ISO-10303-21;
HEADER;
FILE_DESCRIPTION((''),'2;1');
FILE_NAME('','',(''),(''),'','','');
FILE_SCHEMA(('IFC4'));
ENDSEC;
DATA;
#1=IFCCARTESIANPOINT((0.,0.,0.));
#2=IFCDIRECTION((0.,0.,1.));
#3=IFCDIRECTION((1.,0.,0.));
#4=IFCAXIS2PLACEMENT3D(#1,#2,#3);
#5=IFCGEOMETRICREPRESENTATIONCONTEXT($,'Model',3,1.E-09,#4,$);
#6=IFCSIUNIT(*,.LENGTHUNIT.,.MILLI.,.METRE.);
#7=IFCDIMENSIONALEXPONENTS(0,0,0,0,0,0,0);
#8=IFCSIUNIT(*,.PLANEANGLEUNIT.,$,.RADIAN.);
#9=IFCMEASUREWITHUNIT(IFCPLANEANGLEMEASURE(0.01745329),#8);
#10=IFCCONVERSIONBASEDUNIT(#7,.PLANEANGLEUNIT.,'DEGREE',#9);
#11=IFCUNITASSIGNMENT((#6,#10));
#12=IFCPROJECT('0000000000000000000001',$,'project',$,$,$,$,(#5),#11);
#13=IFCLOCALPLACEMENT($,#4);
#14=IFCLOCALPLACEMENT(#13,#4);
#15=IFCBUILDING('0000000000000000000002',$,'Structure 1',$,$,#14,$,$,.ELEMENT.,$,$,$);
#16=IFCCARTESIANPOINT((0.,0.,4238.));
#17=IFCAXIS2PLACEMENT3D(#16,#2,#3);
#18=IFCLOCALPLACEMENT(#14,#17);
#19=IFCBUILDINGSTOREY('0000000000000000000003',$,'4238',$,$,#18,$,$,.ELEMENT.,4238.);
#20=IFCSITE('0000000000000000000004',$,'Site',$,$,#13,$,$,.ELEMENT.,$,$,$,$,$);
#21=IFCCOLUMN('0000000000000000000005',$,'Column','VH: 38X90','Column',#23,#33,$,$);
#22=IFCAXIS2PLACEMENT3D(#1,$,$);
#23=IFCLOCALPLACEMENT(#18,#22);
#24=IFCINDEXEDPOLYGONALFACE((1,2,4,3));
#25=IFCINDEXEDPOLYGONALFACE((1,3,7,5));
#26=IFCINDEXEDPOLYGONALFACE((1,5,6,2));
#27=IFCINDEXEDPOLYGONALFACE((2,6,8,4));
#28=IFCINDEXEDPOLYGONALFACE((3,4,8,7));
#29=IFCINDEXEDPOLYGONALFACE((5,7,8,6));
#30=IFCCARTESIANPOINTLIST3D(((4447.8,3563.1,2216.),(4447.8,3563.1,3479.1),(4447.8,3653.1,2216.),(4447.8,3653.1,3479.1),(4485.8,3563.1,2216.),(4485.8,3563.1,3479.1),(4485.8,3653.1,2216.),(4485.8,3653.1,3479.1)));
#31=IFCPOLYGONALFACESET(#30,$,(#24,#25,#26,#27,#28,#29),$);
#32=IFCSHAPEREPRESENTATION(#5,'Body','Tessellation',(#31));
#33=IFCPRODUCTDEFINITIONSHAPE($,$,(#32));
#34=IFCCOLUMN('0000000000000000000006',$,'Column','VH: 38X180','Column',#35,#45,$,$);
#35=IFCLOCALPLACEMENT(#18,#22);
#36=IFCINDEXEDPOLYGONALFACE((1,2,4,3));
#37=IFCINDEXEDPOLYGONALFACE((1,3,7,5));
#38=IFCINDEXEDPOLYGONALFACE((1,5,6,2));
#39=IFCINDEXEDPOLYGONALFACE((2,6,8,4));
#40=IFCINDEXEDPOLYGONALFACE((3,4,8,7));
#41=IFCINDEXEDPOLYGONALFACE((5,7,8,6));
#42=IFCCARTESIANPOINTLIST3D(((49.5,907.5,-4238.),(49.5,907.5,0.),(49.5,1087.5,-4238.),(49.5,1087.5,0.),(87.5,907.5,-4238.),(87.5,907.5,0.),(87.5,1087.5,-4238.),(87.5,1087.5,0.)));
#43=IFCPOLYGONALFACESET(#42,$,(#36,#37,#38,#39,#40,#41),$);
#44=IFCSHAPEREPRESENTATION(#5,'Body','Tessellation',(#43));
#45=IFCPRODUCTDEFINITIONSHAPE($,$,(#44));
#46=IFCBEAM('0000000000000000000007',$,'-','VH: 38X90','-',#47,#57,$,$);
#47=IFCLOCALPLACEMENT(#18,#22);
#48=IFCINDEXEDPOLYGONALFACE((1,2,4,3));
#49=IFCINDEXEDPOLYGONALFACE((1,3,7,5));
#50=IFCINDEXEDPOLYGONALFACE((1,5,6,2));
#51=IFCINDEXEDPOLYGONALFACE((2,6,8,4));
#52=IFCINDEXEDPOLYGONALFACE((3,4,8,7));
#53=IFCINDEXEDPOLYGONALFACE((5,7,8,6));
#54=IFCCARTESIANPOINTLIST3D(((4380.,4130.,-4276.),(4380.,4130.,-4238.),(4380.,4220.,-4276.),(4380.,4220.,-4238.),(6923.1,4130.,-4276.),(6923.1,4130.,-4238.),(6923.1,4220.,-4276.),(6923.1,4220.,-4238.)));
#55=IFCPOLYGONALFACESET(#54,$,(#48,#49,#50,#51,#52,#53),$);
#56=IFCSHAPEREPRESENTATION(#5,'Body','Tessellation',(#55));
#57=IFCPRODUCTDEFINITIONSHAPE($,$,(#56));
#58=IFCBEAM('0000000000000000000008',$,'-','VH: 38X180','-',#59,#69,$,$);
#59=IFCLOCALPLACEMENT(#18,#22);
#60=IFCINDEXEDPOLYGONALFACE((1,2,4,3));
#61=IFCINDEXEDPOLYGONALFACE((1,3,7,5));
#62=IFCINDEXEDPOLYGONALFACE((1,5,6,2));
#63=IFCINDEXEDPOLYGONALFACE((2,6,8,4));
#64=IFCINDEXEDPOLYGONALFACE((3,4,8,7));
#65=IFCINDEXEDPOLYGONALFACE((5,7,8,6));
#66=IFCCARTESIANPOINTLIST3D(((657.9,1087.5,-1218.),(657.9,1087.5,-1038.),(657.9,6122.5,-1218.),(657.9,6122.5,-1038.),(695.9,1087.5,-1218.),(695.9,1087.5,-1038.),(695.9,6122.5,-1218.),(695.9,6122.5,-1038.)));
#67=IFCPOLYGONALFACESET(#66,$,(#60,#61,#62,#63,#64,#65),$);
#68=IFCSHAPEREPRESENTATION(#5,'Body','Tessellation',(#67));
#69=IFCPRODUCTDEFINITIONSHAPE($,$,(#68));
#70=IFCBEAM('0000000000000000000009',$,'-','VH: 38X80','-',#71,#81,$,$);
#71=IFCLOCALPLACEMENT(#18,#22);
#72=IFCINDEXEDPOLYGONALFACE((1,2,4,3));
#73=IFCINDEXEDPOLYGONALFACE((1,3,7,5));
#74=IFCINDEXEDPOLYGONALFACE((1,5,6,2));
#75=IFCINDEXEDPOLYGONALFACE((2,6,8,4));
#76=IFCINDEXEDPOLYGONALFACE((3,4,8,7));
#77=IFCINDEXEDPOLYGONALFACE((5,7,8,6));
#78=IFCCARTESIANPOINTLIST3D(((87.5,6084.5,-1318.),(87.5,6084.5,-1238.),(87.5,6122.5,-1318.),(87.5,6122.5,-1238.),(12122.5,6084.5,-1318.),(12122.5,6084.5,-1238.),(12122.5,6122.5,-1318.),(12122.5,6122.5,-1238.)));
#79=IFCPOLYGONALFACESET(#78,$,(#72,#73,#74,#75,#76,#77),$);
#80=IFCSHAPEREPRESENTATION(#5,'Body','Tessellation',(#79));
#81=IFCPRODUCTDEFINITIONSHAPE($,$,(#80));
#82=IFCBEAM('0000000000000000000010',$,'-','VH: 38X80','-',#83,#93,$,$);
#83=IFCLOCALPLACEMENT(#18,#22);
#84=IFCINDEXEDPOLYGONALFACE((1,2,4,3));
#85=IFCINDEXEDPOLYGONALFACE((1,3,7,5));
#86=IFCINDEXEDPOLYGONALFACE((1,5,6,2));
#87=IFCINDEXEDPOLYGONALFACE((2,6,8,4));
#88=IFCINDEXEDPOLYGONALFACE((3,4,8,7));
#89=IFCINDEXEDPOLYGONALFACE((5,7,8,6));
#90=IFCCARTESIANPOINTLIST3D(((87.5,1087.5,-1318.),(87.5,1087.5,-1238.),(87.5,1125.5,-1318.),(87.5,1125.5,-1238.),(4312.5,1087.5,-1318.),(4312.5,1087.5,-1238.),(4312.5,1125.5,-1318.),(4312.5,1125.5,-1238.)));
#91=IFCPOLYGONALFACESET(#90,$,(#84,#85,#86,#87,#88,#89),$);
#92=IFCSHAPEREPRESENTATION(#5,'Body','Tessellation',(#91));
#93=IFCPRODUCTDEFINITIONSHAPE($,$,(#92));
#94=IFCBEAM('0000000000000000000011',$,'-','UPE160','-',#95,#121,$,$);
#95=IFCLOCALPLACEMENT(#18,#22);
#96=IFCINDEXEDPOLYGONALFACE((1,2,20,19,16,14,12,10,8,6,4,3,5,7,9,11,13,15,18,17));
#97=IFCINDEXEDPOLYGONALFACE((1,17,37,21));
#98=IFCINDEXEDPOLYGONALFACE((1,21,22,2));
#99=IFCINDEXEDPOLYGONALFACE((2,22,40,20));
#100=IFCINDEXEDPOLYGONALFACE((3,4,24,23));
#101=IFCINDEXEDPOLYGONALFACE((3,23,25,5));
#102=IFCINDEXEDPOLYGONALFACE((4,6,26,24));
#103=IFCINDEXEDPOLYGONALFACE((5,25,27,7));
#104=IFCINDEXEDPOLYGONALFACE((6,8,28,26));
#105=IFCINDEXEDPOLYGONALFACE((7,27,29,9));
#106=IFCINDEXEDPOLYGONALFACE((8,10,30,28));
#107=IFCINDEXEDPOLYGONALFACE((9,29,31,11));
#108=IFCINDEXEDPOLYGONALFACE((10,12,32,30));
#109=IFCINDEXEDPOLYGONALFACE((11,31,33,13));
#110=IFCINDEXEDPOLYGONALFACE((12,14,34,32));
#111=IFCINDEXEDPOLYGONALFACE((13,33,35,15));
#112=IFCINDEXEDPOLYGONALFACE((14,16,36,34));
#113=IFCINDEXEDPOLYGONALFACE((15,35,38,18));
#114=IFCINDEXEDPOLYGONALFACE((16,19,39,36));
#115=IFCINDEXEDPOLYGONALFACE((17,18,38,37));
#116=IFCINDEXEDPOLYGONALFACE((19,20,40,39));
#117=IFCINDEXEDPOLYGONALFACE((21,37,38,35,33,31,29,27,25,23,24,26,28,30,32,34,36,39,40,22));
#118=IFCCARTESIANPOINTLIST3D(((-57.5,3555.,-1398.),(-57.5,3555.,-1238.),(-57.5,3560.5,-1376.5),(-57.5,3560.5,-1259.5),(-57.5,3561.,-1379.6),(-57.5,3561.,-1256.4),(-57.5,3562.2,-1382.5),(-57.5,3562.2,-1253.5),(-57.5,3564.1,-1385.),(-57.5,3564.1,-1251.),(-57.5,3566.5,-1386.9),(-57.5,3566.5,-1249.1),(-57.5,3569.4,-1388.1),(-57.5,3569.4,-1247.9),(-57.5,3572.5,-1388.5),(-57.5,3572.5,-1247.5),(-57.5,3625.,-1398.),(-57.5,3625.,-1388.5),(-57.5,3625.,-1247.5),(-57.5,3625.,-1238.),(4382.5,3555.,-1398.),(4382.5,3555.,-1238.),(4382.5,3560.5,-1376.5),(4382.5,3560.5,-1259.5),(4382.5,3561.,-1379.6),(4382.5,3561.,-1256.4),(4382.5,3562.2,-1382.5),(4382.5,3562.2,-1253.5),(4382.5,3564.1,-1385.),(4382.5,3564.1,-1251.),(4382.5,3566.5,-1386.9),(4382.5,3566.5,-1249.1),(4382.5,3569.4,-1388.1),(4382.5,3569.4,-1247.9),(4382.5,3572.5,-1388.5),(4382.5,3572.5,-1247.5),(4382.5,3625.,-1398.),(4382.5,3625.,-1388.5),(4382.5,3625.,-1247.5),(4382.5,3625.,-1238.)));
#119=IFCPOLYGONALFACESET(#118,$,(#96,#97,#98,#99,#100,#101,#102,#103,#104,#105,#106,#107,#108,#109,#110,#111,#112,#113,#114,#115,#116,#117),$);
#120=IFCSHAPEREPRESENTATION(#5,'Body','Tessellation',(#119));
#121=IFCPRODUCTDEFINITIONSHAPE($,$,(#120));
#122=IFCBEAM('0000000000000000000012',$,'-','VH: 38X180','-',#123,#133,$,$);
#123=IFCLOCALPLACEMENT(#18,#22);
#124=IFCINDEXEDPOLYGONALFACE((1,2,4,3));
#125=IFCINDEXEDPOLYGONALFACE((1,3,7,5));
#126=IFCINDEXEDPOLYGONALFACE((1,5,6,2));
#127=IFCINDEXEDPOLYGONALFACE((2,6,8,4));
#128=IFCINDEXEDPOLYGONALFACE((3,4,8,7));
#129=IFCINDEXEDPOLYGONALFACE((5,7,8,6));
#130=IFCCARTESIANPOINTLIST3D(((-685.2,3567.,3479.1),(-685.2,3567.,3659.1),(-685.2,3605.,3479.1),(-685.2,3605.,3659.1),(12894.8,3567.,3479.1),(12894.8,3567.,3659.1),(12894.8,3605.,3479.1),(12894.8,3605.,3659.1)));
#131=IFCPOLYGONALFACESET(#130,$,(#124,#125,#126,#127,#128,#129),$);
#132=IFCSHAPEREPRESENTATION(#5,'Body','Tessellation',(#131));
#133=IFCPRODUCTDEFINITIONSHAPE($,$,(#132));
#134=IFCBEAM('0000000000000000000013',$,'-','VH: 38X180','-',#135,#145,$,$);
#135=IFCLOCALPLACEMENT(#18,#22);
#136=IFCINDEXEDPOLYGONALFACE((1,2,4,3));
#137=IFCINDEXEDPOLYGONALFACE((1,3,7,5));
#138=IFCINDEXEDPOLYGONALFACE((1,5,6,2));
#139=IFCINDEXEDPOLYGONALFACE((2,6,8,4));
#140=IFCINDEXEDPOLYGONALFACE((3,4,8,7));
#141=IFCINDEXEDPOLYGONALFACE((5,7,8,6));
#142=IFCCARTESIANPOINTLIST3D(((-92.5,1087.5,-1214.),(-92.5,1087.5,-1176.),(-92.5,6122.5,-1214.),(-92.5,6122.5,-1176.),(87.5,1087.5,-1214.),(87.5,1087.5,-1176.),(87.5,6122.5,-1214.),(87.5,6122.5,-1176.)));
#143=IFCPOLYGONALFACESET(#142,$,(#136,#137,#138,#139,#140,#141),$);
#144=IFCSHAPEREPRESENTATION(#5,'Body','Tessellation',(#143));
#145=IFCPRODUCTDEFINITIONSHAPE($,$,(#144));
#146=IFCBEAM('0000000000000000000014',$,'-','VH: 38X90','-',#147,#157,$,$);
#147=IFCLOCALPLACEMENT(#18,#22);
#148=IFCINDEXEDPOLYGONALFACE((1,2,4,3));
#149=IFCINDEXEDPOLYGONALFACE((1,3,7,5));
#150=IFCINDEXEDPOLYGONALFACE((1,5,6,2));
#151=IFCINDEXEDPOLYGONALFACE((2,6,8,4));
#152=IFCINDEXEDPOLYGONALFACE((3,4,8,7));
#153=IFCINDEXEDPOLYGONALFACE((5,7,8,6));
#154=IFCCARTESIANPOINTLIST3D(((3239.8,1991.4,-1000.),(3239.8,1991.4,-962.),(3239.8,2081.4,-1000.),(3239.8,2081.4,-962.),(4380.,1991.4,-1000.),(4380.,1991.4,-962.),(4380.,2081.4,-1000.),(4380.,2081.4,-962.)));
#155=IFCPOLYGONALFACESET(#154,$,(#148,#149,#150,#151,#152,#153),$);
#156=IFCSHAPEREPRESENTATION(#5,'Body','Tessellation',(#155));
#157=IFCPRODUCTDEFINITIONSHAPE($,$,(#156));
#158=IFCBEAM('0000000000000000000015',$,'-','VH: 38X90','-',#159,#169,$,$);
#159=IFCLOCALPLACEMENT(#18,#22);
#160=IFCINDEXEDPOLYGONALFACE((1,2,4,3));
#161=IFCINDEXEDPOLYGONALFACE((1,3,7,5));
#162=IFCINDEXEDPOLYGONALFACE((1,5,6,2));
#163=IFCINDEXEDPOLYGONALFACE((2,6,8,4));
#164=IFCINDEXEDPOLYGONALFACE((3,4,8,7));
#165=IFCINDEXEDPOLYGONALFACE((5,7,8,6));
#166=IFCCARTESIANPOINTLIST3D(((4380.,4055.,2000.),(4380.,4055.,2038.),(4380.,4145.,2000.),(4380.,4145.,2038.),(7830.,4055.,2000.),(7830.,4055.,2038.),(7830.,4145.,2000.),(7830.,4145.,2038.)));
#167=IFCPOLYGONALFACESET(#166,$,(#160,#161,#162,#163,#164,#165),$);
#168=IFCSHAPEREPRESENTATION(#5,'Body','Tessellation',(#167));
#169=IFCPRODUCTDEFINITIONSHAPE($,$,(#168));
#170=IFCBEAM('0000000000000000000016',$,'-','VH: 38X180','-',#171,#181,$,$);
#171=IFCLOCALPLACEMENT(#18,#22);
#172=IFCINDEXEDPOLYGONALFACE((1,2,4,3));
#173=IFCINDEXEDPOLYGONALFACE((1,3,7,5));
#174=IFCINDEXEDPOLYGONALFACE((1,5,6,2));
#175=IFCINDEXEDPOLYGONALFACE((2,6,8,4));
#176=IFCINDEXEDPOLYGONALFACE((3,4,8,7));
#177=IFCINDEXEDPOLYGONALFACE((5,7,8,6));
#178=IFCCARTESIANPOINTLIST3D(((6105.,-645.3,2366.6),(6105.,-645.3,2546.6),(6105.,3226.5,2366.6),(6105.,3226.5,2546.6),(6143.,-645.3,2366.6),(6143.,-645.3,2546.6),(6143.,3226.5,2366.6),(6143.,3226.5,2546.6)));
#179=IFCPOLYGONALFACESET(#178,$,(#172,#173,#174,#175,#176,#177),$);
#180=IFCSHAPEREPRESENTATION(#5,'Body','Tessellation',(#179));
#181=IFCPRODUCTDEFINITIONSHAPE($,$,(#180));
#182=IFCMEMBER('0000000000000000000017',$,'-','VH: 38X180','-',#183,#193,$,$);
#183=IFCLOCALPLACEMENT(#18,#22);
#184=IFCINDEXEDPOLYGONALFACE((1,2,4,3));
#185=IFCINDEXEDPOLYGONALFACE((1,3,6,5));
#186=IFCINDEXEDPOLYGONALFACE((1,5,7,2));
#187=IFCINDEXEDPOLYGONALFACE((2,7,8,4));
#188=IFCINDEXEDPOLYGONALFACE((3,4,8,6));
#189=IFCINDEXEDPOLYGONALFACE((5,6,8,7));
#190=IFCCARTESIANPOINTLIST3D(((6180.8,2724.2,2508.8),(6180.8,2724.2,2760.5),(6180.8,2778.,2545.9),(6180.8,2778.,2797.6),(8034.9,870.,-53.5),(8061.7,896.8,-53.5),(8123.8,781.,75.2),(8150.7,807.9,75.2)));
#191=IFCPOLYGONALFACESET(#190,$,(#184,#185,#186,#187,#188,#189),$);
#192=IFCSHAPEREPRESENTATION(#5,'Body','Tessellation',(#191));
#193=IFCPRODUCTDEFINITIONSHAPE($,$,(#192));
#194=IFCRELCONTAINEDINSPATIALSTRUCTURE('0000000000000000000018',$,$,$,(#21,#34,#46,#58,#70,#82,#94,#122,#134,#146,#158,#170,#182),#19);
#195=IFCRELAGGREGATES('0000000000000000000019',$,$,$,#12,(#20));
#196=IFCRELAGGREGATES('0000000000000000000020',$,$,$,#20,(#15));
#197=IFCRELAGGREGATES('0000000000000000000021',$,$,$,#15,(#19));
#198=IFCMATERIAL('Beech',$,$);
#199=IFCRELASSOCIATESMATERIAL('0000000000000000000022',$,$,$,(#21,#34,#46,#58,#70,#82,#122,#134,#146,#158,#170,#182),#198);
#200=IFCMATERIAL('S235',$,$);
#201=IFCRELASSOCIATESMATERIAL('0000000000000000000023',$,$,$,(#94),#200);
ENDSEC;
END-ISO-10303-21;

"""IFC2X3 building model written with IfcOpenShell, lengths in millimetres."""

from ifc_helpers import new_model, entity, si_unit, converted_unit, frame, frame_2d, origin, origin_with_axes, origin_2d, place, context, project, spatial, rectangle, u_section, extrude, clip, halfspace, material, element, save


model = new_model("IFC2X3")

# Units and contexts
model_context = context("Model", 3, precision=1e-09, world=origin_with_axes())
ifc_project = project(units=[si_unit("LENGTHUNIT", "METRE", prefix="MILLI"), converted_unit("PLANEANGLEUNIT", "DEGREE", entity("IfcPlaneAngleMeasure", 0.01745329), si_unit("PLANEANGLEUNIT", "RADIAN"), dimensions=[0, 0, 0, 0, 0, 0, 0])], contexts=[model_context])

# Site, building, storey
site_placement = place(None, origin_with_axes())
site = spatial("IfcSite", under=ifc_project, at=site_placement, Name="Site", CompositionType="ELEMENT")
building_placement = place(site_placement, origin_with_axes())
building = spatial("IfcBuilding", under=site, at=building_placement, Name="Structure 1", CompositionType="ELEMENT")
storey_placement = place(building_placement, frame((0.0, 0.0, 4238.0), z_axis=(0.0, 0.0, 1.0), x_axis=(1.0, 0.0, 0.0)))
storey = spatial("IfcBuildingStorey", under=building, at=storey_placement, Name="4238", CompositionType="ELEMENT", Elevation=4238.0)

# Columns
ifc_material_1 = material(Name="S235")
ifc_material_2 = material(Name="Beech")
column_1_placement = place(None, frame((4466.8, 3608.1, 6454.0), z_axis=(0.0, 0.0, -1.0), x_axis=(-1.0, 0.0, 0.0)))
element("IfcColumn", 1, at=column_1_placement, inside=storey, material=ifc_material_2, Name="Column", Description="VH: 38X90", ObjectType="Column", context=model_context, shape_type="Clipping", body=[
    clip(extrude(rectangle(XDim=38.0, YDim=90.0, at=origin_2d()), origin(), (0.0, 0.0, -1.0), 1493.8), halfspace(frame((4466.8, -3608.1, -1263.1), z_axis=(0.0, 0.0, 1.0), x_axis=(1.0, 0.0, 0.0)), True)),
])
column_2_placement = place(None, frame((68.5, 997.5, 0.0), z_axis=(0.0, 0.0, -1.0), x_axis=(-1.0, 0.0, 0.0)))
element("IfcColumn", 2, at=column_2_placement, inside=storey, material=ifc_material_2, Name="Column", Description="VH: 38X180", ObjectType="Column", context=model_context, shape_type="SweptSolid", body=[
    extrude(rectangle(XDim=38.0, YDim=180.0, at=origin_2d()), origin(), (0.0, 0.0, -1.0), 4238.0),
])

# Beams
beam_1_placement = place(None, frame((4380.0, 4175.0, -19.0), z_axis=(-1.0, 0.0, 0.0), x_axis=(0.0, 0.0, -1.0)))
element("IfcBeam", 3, at=beam_1_placement, inside=storey, material=ifc_material_2, Name="-", Description="VH: 38X90", ObjectType="-", context=model_context, shape_type="SweptSolid", body=[
    extrude(rectangle(XDim=38.0, YDim=90.0, at=origin_2d()), origin(), (0.0, 0.0, -1.0), 2543.1),
])
beam_2_placement = place(None, frame((676.9, 6122.5, 3110.0), z_axis=(0.000003, 1.0, 0.0), x_axis=(-1.0, 0.000003, 0.0)))
element("IfcBeam", 4, at=beam_2_placement, inside=storey, material=ifc_material_2, Name="-", Description="VH: 38X180", ObjectType="-", context=model_context, shape_type="SweptSolid", body=[
    extrude(rectangle(XDim=38.0, YDim=180.0, at=origin_2d()), origin(), (0.0, 0.0, -1.0), 5035.0),
])
beam_3_placement = place(None, frame((87.5, 6103.5, 2960.0), z_axis=(-1.0, 0.0, 0.0), x_axis=(0.0, -1.0, 0.0)))
element("IfcBeam", 5, at=beam_3_placement, inside=storey, material=ifc_material_2, Name="-", Description="VH: 38X80", ObjectType="-", context=model_context, shape_type="SweptSolid", body=[
    extrude(rectangle(XDim=38.0, YDim=80.0, at=origin_2d()), origin(), (0.0, 0.0, -1.0), 12035.0),
])
beam_4_placement = place(None, frame((87.5, 1106.5, 2960.0), z_axis=(-1.0, 0.0, 0.0), x_axis=(0.0, -1.0, 0.0)))
element("IfcBeam", 6, at=beam_4_placement, inside=storey, material=ifc_material_2, Name="-", Description="VH: 38X80", ObjectType="-", context=model_context, shape_type="SweptSolid", body=[
    extrude(rectangle(XDim=38.0, YDim=80.0, at=origin_2d()), origin(), (0.0, 0.0, -1.0), 4225.0),
])
beam_5_placement = place(None, frame((-57.5, 3577.7, 2920.0), z_axis=(1.0, 0.0, 0.0), x_axis=(0.0, 1.0, 0.0)))
element("IfcBeam", 7, at=beam_5_placement, inside=storey, material=ifc_material_1, Name="-", Description="UPE160", ObjectType="-", context=model_context, shape_type="SweptSolid", body=[
    extrude(u_section(Depth=160.0, FlangeWidth=70.0, WebThickness=5.5, FlangeThickness=9.5, FilletRadius=12.0, EdgeRadius=0.0, FlangeSlope=0.0, at=frame_2d((12.3, 0.0))), origin(), (0.0, 0.0, 1.0), 4440.0),
])
beam_6_placement = place(None, frame((-685.2, 3586.0, 7807.1), z_axis=(-1.0, 0.0, 0.0), x_axis=(0.0, -1.0, 0.0)))
element("IfcBeam", 8, at=beam_6_placement, inside=storey, material=ifc_material_2, Name="-", Description="VH: 38X180", ObjectType="-", context=model_context, shape_type="SweptSolid", body=[
    extrude(rectangle(XDim=38.0, YDim=180.0, at=origin_2d()), origin(), (0.0, 0.0, -1.0), 13580.0),
])
beam_7_placement = place(None, frame((-2.5, 6122.5, 3043.0), z_axis=(0.0, -1.0, 0.0), x_axis=(0.0, 0.0, 1.0)))
element("IfcBeam", 9, at=beam_7_placement, inside=storey, material=ifc_material_2, Name="-", Description="VH: 38X180", ObjectType="-", context=model_context, shape_type="SweptSolid", body=[
    extrude(rectangle(XDim=38.0, YDim=180.0, at=origin_2d()), origin(), (0.0, 0.0, 1.0), 5035.0),
])
beam_8_placement = place(None, frame((3239.8, 2036.4, 3257.0), z_axis=(-1.0, 0.0, 0.0), x_axis=(0.0, 0.0, -1.0)))
element("IfcBeam", 10, at=beam_8_placement, inside=storey, material=ifc_material_2, Name="-", Description="VH: 38X90", ObjectType="-", context=model_context, shape_type="SweptSolid", body=[
    extrude(rectangle(XDim=38.0, YDim=90.0, at=origin_2d()), origin(), (0.0, 0.0, -1.0), 1140.2),
])
beam_9_placement = place(None, frame((4380.0, 4100.0, 6257.0), z_axis=(-1.0, 0.0, 0.0), x_axis=(0.0, 0.0, -1.0)))
element("IfcBeam", 11, at=beam_9_placement, inside=storey, material=ifc_material_2, Name="-", Description="VH: 38X90", ObjectType="-", context=model_context, shape_type="SweptSolid", body=[
    extrude(rectangle(XDim=38.0, YDim=90.0, at=origin_2d()), origin(), (0.0, 0.0, -1.0), 3450.0),
])
beam_10_placement = place(None, frame((6124.0, -645.3, 6694.6), z_axis=(0.0, -1.0, 0.0), x_axis=(-1.0, 0.0, 0.0)))
element("IfcBeam", 12, at=beam_10_placement, inside=storey, material=ifc_material_2, Name="-", Description="VH: 38X180", ObjectType="-", context=model_context, shape_type="SweptSolid", body=[
    extrude(rectangle(XDim=38.0, YDim=180.0, at=origin_2d()), origin(), (0.0, 0.0, -1.0), 3871.8),
])

# Member
member_1_placement = place(None, frame((8092.8, 838.9, 4248.9), z_axis=(0.505723, -0.505767, -0.698888), x_axis=(0.707137, 0.707076, 0.0)))
element("IfcMember", 13, at=member_1_placement, inside=storey, material=ifc_material_2, Name="-", Description="VH: 38X180", ObjectType="-", context=model_context, shape_type="Clipping", body=[
    clip(extrude(rectangle(XDim=38.0, YDim=180.0, at=origin_2d()), origin(), (0.0, 0.0, -1.0), 4351.8), halfspace(frame((-1945.2, -3569.2, 2426.8), z_axis=(0.707137, 0.494167, 0.505723), x_axis=(0.707076, -0.494209, -0.505767)), True)),
])

save(model, "model.ifc")
